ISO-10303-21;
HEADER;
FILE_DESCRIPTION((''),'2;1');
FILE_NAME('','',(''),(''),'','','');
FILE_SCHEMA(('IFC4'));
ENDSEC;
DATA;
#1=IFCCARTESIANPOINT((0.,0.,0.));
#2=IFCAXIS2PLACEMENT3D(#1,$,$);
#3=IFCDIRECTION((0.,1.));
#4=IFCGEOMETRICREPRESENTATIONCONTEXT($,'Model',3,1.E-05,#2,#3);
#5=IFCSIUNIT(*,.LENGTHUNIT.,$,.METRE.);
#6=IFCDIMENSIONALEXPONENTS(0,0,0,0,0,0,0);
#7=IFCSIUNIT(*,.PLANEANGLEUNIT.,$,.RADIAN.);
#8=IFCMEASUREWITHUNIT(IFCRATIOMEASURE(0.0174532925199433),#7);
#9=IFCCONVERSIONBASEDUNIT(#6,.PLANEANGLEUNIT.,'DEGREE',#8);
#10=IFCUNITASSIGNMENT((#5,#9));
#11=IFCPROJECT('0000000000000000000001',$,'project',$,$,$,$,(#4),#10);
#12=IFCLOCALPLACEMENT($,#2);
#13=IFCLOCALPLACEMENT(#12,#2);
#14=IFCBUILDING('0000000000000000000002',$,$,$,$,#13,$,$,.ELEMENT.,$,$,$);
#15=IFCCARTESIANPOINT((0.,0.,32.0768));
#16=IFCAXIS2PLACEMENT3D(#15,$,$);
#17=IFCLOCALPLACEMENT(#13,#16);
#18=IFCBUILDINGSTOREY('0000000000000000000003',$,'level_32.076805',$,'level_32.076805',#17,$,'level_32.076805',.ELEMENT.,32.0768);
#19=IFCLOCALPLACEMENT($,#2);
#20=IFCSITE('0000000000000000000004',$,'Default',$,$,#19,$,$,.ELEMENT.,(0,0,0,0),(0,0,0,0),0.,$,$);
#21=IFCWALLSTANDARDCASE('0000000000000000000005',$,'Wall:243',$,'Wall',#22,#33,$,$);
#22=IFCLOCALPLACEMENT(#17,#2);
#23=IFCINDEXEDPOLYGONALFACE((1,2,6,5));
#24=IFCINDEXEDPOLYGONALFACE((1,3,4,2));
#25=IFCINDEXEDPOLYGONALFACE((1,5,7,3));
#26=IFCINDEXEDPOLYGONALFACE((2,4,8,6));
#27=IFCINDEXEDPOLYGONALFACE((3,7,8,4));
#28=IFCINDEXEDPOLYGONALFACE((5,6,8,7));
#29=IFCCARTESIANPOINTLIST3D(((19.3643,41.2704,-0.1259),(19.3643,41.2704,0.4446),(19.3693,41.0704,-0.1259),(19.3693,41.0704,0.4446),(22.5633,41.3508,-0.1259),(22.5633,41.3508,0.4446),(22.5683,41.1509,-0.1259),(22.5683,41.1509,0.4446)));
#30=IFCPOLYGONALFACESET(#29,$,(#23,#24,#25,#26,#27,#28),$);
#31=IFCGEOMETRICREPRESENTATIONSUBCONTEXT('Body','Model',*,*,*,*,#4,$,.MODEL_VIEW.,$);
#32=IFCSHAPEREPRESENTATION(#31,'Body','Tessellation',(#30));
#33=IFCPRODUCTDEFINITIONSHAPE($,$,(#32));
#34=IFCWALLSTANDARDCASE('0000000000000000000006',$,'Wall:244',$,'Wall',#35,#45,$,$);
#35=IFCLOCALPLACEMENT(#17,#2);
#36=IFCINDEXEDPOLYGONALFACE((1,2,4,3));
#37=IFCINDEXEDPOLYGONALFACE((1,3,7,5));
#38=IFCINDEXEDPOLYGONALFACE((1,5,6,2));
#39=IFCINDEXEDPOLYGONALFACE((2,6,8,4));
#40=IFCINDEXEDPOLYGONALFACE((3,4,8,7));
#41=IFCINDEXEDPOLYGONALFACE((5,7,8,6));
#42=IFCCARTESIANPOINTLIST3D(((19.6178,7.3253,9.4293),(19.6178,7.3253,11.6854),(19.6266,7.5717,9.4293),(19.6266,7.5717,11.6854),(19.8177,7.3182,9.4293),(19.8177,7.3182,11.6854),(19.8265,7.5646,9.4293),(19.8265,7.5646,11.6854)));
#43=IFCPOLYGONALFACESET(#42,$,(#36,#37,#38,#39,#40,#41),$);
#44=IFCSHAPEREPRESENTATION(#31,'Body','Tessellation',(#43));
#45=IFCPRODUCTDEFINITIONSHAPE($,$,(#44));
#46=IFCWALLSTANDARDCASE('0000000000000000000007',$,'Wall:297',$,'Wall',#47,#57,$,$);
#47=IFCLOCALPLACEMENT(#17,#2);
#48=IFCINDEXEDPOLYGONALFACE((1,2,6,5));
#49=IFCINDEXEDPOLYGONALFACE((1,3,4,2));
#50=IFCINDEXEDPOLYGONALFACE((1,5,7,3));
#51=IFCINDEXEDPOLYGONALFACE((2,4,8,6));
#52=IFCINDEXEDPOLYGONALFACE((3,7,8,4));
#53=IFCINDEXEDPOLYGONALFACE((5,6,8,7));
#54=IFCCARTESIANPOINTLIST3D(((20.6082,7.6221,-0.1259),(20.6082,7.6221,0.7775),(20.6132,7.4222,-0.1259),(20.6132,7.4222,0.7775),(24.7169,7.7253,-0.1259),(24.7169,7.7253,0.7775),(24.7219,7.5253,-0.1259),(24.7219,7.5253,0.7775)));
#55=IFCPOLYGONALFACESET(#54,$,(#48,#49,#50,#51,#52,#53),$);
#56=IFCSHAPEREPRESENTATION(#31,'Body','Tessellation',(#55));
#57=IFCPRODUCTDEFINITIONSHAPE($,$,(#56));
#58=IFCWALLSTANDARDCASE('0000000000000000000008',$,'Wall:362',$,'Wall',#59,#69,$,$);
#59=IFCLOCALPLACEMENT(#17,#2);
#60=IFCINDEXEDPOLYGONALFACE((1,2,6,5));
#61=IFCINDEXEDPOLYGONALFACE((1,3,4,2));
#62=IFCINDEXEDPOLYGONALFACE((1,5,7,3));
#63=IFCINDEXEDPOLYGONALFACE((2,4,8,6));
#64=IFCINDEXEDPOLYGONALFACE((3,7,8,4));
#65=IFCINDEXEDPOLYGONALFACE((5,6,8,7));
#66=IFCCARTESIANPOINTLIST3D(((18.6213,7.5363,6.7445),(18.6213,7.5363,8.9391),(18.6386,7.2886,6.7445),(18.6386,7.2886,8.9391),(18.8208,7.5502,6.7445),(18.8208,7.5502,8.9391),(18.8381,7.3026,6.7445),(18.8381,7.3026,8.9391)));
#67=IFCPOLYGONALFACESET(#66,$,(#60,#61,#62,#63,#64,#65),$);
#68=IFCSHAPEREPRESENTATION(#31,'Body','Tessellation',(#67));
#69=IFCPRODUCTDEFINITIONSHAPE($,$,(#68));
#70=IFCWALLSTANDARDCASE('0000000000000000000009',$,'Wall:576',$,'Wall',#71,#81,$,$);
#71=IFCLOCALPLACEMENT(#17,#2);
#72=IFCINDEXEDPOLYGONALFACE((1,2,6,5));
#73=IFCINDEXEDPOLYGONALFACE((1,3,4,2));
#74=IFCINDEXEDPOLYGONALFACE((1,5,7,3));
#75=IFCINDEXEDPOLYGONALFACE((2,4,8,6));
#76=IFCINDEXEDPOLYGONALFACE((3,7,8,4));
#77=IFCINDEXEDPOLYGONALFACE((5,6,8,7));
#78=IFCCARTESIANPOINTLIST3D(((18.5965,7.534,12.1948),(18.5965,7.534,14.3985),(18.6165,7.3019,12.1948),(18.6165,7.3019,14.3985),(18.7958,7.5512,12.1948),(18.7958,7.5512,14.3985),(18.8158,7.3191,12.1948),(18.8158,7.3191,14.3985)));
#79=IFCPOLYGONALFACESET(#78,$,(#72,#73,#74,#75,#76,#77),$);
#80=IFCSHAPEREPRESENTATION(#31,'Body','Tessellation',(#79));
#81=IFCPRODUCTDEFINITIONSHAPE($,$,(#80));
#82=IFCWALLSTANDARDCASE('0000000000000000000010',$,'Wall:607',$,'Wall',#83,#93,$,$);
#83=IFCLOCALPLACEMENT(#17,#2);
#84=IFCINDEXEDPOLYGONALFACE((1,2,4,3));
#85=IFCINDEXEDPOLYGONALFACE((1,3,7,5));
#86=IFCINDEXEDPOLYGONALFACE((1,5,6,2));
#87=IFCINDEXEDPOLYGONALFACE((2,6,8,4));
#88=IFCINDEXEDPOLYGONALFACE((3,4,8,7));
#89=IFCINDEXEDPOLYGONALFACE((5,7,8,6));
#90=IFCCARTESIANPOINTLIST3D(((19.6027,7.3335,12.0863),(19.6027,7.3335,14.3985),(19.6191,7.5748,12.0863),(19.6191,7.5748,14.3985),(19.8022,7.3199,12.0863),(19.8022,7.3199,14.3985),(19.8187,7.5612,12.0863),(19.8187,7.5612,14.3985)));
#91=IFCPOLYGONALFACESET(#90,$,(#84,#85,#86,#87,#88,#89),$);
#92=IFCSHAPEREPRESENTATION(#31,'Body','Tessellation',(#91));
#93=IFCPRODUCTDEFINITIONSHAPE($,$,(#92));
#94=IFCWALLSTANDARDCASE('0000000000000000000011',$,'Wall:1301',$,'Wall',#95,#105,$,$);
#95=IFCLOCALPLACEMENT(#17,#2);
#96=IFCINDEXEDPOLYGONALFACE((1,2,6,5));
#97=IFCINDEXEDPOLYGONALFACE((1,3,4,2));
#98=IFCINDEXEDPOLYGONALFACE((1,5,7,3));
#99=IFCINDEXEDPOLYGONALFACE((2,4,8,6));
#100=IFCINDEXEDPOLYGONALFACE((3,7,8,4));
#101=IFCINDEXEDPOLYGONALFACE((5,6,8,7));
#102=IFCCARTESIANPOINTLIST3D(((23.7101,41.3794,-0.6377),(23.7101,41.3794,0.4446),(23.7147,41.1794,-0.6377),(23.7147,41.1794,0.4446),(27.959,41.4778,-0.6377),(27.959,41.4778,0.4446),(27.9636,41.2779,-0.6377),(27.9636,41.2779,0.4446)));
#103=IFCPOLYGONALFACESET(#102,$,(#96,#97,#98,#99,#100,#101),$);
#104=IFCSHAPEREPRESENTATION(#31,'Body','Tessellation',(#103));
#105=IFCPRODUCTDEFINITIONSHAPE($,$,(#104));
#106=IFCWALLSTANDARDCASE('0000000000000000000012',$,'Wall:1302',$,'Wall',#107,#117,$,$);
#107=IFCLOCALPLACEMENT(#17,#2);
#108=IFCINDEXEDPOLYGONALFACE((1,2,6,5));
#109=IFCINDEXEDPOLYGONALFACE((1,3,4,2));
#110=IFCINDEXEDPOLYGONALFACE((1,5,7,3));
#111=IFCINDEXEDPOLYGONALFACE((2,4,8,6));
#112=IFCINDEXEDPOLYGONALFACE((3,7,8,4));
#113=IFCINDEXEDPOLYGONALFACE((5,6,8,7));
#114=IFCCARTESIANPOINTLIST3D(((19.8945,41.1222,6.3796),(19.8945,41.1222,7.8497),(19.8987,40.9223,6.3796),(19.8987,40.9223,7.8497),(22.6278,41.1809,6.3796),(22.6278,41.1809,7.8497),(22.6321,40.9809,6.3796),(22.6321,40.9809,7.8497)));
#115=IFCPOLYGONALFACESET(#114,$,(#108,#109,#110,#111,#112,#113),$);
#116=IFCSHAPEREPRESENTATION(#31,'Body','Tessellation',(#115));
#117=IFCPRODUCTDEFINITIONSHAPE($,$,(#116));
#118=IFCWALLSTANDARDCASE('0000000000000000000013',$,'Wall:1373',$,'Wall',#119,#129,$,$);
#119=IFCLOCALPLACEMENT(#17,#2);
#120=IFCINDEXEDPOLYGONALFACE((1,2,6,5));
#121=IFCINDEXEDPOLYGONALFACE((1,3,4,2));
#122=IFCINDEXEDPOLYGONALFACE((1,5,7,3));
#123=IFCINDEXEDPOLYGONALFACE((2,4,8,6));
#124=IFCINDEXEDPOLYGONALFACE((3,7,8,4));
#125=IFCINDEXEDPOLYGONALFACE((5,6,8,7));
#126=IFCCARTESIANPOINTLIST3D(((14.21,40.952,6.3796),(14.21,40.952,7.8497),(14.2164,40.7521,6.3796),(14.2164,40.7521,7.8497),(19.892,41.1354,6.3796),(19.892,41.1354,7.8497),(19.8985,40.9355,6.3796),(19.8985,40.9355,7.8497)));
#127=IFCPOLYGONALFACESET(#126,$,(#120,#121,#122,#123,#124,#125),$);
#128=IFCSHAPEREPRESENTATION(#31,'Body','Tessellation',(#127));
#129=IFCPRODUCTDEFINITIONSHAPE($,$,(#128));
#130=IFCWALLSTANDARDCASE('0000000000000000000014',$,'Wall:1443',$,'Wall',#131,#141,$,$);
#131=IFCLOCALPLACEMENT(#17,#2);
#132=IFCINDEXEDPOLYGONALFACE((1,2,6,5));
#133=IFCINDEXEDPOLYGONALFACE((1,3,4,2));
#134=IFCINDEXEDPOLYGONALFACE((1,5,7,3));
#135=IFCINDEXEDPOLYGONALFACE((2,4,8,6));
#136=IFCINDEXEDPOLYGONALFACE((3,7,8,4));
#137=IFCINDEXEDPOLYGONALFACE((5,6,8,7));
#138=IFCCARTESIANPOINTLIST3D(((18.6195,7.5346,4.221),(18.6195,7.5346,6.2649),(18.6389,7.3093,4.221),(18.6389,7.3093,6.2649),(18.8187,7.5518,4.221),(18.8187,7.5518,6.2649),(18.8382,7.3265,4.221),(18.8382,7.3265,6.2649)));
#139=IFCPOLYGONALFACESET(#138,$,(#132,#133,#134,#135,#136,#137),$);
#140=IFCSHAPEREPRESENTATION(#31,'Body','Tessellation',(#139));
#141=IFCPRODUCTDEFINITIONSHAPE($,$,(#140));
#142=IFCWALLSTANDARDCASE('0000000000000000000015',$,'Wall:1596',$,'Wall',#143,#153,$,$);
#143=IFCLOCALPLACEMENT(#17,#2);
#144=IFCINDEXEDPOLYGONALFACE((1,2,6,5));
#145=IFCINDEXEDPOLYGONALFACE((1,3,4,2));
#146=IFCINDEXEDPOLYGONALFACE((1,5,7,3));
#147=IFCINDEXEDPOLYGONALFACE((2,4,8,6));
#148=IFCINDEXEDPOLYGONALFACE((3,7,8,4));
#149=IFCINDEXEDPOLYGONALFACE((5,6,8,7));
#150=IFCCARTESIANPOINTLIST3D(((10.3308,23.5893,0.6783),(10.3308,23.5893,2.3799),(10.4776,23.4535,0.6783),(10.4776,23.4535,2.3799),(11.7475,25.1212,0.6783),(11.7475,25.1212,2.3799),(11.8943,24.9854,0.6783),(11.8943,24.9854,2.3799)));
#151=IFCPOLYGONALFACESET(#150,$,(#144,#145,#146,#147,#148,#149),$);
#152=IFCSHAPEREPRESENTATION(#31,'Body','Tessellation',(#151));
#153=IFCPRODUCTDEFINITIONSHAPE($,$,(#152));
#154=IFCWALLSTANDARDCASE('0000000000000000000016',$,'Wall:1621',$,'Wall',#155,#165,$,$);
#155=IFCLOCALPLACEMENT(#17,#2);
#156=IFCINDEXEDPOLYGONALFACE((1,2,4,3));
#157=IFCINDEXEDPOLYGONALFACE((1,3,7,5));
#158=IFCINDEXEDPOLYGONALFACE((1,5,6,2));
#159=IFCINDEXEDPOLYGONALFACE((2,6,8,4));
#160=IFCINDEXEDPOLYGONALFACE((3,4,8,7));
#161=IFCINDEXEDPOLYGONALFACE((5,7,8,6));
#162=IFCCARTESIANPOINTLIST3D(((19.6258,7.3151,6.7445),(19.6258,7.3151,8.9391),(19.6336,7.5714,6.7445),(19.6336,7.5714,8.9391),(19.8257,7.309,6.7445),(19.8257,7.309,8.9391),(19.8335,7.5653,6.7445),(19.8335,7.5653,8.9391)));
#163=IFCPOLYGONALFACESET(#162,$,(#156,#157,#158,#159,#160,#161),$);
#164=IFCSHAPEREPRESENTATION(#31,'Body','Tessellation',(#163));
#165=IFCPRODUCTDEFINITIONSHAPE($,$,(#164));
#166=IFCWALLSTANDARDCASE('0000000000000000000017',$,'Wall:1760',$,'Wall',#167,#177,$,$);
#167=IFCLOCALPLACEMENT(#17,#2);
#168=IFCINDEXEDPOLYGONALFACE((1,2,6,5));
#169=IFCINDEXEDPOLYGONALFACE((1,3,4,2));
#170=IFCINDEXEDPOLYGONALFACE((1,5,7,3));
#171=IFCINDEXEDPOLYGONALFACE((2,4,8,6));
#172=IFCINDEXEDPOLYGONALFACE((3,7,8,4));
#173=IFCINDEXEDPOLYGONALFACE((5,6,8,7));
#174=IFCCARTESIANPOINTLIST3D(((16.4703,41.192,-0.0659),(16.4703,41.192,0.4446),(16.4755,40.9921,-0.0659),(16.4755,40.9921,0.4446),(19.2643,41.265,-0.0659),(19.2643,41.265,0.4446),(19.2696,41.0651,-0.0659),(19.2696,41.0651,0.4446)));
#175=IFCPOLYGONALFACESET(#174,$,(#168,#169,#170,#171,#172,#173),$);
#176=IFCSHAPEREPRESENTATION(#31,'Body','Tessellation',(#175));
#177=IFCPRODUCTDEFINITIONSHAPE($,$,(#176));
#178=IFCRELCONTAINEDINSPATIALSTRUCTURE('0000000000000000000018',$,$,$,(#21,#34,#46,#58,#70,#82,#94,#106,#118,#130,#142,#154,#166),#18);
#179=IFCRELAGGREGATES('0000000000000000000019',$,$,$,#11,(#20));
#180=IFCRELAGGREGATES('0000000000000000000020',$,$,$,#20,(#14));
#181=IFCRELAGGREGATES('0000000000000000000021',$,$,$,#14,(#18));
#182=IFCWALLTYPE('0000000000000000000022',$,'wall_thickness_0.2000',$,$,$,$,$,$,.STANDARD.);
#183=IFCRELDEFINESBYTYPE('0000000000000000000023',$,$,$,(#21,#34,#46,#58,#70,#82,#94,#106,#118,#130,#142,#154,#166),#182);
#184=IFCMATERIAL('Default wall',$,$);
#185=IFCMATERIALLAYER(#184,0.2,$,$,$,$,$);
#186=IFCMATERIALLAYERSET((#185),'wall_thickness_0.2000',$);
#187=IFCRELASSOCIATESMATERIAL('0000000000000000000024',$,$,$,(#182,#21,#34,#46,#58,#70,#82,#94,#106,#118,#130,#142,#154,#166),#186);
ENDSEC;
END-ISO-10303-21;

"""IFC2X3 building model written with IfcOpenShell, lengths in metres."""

from ifc_helpers import new_model, entity, si_unit, converted_unit, direction, frame, origin, place, context, subcontext, project, spatial, polyline, outline, extrude, material, layer, layer_set, layer_usage, type_object, element, save


model = new_model("IFC2X3")

# Units and contexts
model_context = context("Model", 3, precision=1e-05, world=origin(), true_north=direction((0.0, 1.0)))
body_context = subcontext(model_context, "Body", "Model", "MODEL_VIEW")
ifc_project = project(units=[si_unit("LENGTHUNIT", "METRE"), converted_unit("PLANEANGLEUNIT", "DEGREE", entity("IfcRatioMeasure", 0.0174532925199433), si_unit("PLANEANGLEUNIT", "RADIAN"), dimensions=[0, 0, 0, 0, 0, 0, 0])], contexts=[model_context])

# Site, building, storey
site_placement = place(None, origin())
site = spatial("IfcSite", under=ifc_project, at=site_placement, Name="Default", CompositionType="ELEMENT", RefLatitude=(0, 0, 0, 0), RefLongitude=(0, 0, 0, 0), RefElevation=0.0)
placement_1 = place(None, origin())
building_placement = place(placement_1, origin())
building = spatial("IfcBuilding", under=site, at=building_placement, CompositionType="ELEMENT")
storey_placement = place(building_placement, frame((0.0, 0.0, 32.0768)))
storey = spatial("IfcBuildingStorey", under=building, at=storey_placement, Name="level_32.076805", ObjectType="level_32.076805", LongName="level_32.076805", CompositionType="ELEMENT", Elevation=32.0768)

# Walls
ifc_material = material(Name="Default wall")
ifc_layer = layer(ifc_material, 0.2)
ifc_layer_set = layer_set([ifc_layer], Name="wall_thickness_0.2000")
ifc_layer_usage = layer_usage(ifc_layer_set, "AXIS2", "POSITIVE", -0.1)
wall_type = type_object("IfcWallType", Name="wall_thickness_0.2000", PredefinedType="STANDARD", material=ifc_layer_set)
placement_2 = place(building_placement, frame((0.0, 0.0, 31.9509)))
wall_1_placement = place(placement_2, frame((19.3668, 41.1704, 0.0), z_axis=(0.0, 0.0, 1.0), x_axis=(0.999684, 0.025132, 0.0)))
element("IfcWallStandardCase", 1, at=wall_1_placement, inside=storey, type_object=wall_type, material=ifc_layer_usage, Name="Wall:243", ObjectType="Wall", context=body_context, shape_type="SweptSolid", body=[
    extrude(outline(polyline([(3.2, -0.1), (3.2, 0.1), (0.0, 0.1), (0.0, -0.1), (3.2, -0.1)])), origin(), (0.0, 0.0, 1.0), 0.5705),
])
placement_3 = place(building_placement, frame((0.0, 0.0, 41.5061)))
wall_2_placement = place(placement_3, frame((19.7178, 7.3217, 0.0), z_axis=(0.0, 0.0, 1.0), x_axis=(0.035704, 0.999362, 0.0)))
element("IfcWallStandardCase", 2, at=wall_2_placement, inside=storey, type_object=wall_type, material=ifc_layer_usage, Name="Wall:244", ObjectType="Wall", context=body_context, shape_type="SweptSolid", body=[
    extrude(outline(polyline([(0.2466, -0.1), (0.2466, 0.1), (0.0, 0.1), (0.0, -0.1), (0.2466, -0.1)])), origin(), (0.0, 0.0, 1.0), 2.2561),
])
placement_4 = place(building_placement, frame((0.0, 0.0, 31.9509)))
wall_3_placement = place(placement_4, frame((20.6107, 7.5221, 0.0), z_axis=(0.0, 0.0, 1.0), x_axis=(0.999685, 0.025105, 0.0)))
element("IfcWallStandardCase", 3, at=wall_3_placement, inside=storey, type_object=wall_type, material=ifc_layer_usage, Name="Wall:297", ObjectType="Wall", context=body_context, shape_type="SweptSolid", body=[
    extrude(outline(polyline([(4.11, -0.1), (4.11, 0.1), (0.0, 0.1), (0.0, -0.1), (4.11, -0.1)])), origin(), (0.0, 0.0, 1.0), 0.9035),
])
placement_5 = place(building_placement, frame((0.0, 0.0, 38.8213)))
wall_4_placement = place(placement_5, frame((18.7211, 7.5432, 0.0), z_axis=(0.0, 0.0, 1.0), x_axis=(0.069719, -0.997567, 0.0)))
element("IfcWallStandardCase", 4, at=wall_4_placement, inside=storey, type_object=wall_type, material=ifc_layer_usage, Name="Wall:362", ObjectType="Wall", context=body_context, shape_type="SweptSolid", body=[
    extrude(outline(polyline([(0.2482, -0.1), (0.2482, 0.1), (0.0, 0.1), (0.0, -0.1), (0.2482, -0.1)])), origin(), (0.0, 0.0, 1.0), 2.1946),
])
placement_6 = place(building_placement, frame((0.0, 0.0, 44.2716)))
wall_5_placement = place(placement_6, frame((18.7161, 7.3105, 0.0), z_axis=(0.0, 0.0, 1.0), x_axis=(-0.08585, 0.996308, 0.0)))
element("IfcWallStandardCase", 5, at=wall_5_placement, inside=storey, type_object=wall_type, material=ifc_layer_usage, Name="Wall:576", ObjectType="Wall", context=body_context, shape_type="SweptSolid", body=[
    extrude(outline(polyline([(0.233, -0.1), (0.233, 0.1), (0.0, 0.1), (0.0, -0.1), (0.233, -0.1)])), origin(), (0.0, 0.0, 1.0), 2.2037),
])
placement_7 = place(building_placement, frame((0.0, 0.0, 44.1631)))
wall_6_placement = place(placement_7, frame((19.7024, 7.3267, 0.0), z_axis=(0.0, 0.0, 1.0), x_axis=(0.068044, 0.997682, 0.0)))
element("IfcWallStandardCase", 6, at=wall_6_placement, inside=storey, type_object=wall_type, material=ifc_layer_usage, Name="Wall:607", ObjectType="Wall", context=body_context, shape_type="SweptSolid", body=[
    extrude(outline(polyline([(0.2419, -0.1), (0.2419, 0.1), (0.0, 0.1), (0.0, -0.1), (0.2419, -0.1)])), origin(), (0.0, 0.0, 1.0), 2.3122),
])
placement_8 = place(building_placement, frame((0.0, 0.0, 31.4391)))
wall_7_placement = place(placement_8, frame((23.7124, 41.2794, 0.0), z_axis=(0.0, 0.0, 1.0), x_axis=(0.999732, 0.023165, 0.0)))
element("IfcWallStandardCase", 7, at=wall_7_placement, inside=storey, type_object=wall_type, material=ifc_layer_usage, Name="Wall:1301", ObjectType="Wall", context=body_context, shape_type="SweptSolid", body=[
    extrude(outline(polyline([(4.25, -0.1), (4.25, 0.1), (0.0, 0.1), (0.0, -0.1), (4.25, -0.1)])), origin(), (0.0, 0.0, 1.0), 1.0823),
])
placement_9 = place(building_placement, frame((0.0, 0.0, 38.4564)))
wall_8_placement = place(placement_9, frame((19.8966, 41.0223, 0.0), z_axis=(0.0, 0.0, 1.0), x_axis=(0.99977, 0.021444, 0.0)))
element("IfcWallStandardCase", 8, at=wall_8_placement, inside=storey, type_object=wall_type, material=ifc_layer_usage, Name="Wall:1302", ObjectType="Wall", context=body_context, shape_type="SweptSolid", body=[
    extrude(outline(polyline([(2.734, -0.1), (2.734, 0.1), (0.0, 0.1), (0.0, -0.1), (2.734, -0.1)])), origin(), (0.0, 0.0, 1.0), 1.4701),
])
placement_10 = place(building_placement, frame((0.0, 0.0, 38.4564)))
wall_9_placement = place(placement_10, frame((14.2132, 40.852, 0.0), z_axis=(0.0, 0.0, 1.0), x_axis=(0.999479, 0.032274, 0.0)))
element("IfcWallStandardCase", 9, at=wall_9_placement, inside=storey, type_object=wall_type, material=ifc_layer_usage, Name="Wall:1373", ObjectType="Wall", context=body_context, shape_type="SweptSolid", body=[
    extrude(outline(polyline([(5.685, -0.1), (5.685, 0.1), (0.0, 0.1), (0.0, -0.1), (5.685, -0.1)])), origin(), (0.0, 0.0, 1.0), 1.4701),
])
placement_11 = place(building_placement, frame((0.0, 0.0, 36.2978)))
wall_10_placement = place(placement_11, frame((18.7191, 7.5432, 0.0), z_axis=(0.0, 0.0, 1.0), x_axis=(0.086018, -0.996294, 0.0)))
element("IfcWallStandardCase", 10, at=wall_10_placement, inside=storey, type_object=wall_type, material=ifc_layer_usage, Name="Wall:1443", ObjectType="Wall", context=body_context, shape_type="SweptSolid", body=[
    extrude(outline(polyline([(0.2261, -0.1), (0.2261, 0.1), (0.0, 0.1), (0.0, -0.1), (0.2261, -0.1)])), origin(), (0.0, 0.0, 1.0), 2.0439),
])
placement_12 = place(building_placement, frame((0.0, 0.0, 32.7551)))
wall_11_placement = place(placement_12, frame((11.8209, 25.0533, 0.0), z_axis=(0.0, 0.0, 1.0), x_axis=(-0.678953, -0.734181, 0.0)))
element("IfcWallStandardCase", 11, at=wall_11_placement, inside=storey, type_object=wall_type, material=ifc_layer_usage, Name="Wall:1596", ObjectType="Wall", context=body_context, shape_type="SweptSolid", body=[
    extrude(outline(polyline([(2.0866, -0.1), (2.0866, 0.1), (0.0, 0.1), (0.0, -0.1), (2.0866, -0.1)])), origin(), (0.0, 0.0, 1.0), 1.7016),
])
placement_13 = place(building_placement, frame((0.0, 0.0, 38.8213)))
wall_12_placement = place(placement_13, frame((19.7257, 7.312, 0.0), z_axis=(0.0, 0.0, 1.0), x_axis=(0.030551, 0.999533, 0.0)))
element("IfcWallStandardCase", 12, at=wall_12_placement, inside=storey, type_object=wall_type, material=ifc_layer_usage, Name="Wall:1621", ObjectType="Wall", context=body_context, shape_type="SweptSolid", body=[
    extrude(outline(polyline([(0.2564, -0.1), (0.2564, 0.1), (0.0, 0.1), (0.0, -0.1), (0.2564, -0.1)])), origin(), (0.0, 0.0, 1.0), 2.1946),
])
placement_14 = place(building_placement, frame((0.0, 0.0, 32.0109)))
wall_13_placement = place(placement_14, frame((16.4729, 41.092, 0.0), z_axis=(0.0, 0.0, 1.0), x_axis=(0.999659, 0.026127, 0.0)))
element("IfcWallStandardCase", 13, at=wall_13_placement, inside=storey, type_object=wall_type, material=ifc_layer_usage, Name="Wall:1760", ObjectType="Wall", context=body_context, shape_type="SweptSolid", body=[
    extrude(outline(polyline([(2.795, -0.1), (2.795, 0.1), (0.0, 0.1), (0.0, -0.1), (2.795, -0.1)])), origin(), (0.0, 0.0, 1.0), 0.5105),
])

save(model, "model.ifc")
